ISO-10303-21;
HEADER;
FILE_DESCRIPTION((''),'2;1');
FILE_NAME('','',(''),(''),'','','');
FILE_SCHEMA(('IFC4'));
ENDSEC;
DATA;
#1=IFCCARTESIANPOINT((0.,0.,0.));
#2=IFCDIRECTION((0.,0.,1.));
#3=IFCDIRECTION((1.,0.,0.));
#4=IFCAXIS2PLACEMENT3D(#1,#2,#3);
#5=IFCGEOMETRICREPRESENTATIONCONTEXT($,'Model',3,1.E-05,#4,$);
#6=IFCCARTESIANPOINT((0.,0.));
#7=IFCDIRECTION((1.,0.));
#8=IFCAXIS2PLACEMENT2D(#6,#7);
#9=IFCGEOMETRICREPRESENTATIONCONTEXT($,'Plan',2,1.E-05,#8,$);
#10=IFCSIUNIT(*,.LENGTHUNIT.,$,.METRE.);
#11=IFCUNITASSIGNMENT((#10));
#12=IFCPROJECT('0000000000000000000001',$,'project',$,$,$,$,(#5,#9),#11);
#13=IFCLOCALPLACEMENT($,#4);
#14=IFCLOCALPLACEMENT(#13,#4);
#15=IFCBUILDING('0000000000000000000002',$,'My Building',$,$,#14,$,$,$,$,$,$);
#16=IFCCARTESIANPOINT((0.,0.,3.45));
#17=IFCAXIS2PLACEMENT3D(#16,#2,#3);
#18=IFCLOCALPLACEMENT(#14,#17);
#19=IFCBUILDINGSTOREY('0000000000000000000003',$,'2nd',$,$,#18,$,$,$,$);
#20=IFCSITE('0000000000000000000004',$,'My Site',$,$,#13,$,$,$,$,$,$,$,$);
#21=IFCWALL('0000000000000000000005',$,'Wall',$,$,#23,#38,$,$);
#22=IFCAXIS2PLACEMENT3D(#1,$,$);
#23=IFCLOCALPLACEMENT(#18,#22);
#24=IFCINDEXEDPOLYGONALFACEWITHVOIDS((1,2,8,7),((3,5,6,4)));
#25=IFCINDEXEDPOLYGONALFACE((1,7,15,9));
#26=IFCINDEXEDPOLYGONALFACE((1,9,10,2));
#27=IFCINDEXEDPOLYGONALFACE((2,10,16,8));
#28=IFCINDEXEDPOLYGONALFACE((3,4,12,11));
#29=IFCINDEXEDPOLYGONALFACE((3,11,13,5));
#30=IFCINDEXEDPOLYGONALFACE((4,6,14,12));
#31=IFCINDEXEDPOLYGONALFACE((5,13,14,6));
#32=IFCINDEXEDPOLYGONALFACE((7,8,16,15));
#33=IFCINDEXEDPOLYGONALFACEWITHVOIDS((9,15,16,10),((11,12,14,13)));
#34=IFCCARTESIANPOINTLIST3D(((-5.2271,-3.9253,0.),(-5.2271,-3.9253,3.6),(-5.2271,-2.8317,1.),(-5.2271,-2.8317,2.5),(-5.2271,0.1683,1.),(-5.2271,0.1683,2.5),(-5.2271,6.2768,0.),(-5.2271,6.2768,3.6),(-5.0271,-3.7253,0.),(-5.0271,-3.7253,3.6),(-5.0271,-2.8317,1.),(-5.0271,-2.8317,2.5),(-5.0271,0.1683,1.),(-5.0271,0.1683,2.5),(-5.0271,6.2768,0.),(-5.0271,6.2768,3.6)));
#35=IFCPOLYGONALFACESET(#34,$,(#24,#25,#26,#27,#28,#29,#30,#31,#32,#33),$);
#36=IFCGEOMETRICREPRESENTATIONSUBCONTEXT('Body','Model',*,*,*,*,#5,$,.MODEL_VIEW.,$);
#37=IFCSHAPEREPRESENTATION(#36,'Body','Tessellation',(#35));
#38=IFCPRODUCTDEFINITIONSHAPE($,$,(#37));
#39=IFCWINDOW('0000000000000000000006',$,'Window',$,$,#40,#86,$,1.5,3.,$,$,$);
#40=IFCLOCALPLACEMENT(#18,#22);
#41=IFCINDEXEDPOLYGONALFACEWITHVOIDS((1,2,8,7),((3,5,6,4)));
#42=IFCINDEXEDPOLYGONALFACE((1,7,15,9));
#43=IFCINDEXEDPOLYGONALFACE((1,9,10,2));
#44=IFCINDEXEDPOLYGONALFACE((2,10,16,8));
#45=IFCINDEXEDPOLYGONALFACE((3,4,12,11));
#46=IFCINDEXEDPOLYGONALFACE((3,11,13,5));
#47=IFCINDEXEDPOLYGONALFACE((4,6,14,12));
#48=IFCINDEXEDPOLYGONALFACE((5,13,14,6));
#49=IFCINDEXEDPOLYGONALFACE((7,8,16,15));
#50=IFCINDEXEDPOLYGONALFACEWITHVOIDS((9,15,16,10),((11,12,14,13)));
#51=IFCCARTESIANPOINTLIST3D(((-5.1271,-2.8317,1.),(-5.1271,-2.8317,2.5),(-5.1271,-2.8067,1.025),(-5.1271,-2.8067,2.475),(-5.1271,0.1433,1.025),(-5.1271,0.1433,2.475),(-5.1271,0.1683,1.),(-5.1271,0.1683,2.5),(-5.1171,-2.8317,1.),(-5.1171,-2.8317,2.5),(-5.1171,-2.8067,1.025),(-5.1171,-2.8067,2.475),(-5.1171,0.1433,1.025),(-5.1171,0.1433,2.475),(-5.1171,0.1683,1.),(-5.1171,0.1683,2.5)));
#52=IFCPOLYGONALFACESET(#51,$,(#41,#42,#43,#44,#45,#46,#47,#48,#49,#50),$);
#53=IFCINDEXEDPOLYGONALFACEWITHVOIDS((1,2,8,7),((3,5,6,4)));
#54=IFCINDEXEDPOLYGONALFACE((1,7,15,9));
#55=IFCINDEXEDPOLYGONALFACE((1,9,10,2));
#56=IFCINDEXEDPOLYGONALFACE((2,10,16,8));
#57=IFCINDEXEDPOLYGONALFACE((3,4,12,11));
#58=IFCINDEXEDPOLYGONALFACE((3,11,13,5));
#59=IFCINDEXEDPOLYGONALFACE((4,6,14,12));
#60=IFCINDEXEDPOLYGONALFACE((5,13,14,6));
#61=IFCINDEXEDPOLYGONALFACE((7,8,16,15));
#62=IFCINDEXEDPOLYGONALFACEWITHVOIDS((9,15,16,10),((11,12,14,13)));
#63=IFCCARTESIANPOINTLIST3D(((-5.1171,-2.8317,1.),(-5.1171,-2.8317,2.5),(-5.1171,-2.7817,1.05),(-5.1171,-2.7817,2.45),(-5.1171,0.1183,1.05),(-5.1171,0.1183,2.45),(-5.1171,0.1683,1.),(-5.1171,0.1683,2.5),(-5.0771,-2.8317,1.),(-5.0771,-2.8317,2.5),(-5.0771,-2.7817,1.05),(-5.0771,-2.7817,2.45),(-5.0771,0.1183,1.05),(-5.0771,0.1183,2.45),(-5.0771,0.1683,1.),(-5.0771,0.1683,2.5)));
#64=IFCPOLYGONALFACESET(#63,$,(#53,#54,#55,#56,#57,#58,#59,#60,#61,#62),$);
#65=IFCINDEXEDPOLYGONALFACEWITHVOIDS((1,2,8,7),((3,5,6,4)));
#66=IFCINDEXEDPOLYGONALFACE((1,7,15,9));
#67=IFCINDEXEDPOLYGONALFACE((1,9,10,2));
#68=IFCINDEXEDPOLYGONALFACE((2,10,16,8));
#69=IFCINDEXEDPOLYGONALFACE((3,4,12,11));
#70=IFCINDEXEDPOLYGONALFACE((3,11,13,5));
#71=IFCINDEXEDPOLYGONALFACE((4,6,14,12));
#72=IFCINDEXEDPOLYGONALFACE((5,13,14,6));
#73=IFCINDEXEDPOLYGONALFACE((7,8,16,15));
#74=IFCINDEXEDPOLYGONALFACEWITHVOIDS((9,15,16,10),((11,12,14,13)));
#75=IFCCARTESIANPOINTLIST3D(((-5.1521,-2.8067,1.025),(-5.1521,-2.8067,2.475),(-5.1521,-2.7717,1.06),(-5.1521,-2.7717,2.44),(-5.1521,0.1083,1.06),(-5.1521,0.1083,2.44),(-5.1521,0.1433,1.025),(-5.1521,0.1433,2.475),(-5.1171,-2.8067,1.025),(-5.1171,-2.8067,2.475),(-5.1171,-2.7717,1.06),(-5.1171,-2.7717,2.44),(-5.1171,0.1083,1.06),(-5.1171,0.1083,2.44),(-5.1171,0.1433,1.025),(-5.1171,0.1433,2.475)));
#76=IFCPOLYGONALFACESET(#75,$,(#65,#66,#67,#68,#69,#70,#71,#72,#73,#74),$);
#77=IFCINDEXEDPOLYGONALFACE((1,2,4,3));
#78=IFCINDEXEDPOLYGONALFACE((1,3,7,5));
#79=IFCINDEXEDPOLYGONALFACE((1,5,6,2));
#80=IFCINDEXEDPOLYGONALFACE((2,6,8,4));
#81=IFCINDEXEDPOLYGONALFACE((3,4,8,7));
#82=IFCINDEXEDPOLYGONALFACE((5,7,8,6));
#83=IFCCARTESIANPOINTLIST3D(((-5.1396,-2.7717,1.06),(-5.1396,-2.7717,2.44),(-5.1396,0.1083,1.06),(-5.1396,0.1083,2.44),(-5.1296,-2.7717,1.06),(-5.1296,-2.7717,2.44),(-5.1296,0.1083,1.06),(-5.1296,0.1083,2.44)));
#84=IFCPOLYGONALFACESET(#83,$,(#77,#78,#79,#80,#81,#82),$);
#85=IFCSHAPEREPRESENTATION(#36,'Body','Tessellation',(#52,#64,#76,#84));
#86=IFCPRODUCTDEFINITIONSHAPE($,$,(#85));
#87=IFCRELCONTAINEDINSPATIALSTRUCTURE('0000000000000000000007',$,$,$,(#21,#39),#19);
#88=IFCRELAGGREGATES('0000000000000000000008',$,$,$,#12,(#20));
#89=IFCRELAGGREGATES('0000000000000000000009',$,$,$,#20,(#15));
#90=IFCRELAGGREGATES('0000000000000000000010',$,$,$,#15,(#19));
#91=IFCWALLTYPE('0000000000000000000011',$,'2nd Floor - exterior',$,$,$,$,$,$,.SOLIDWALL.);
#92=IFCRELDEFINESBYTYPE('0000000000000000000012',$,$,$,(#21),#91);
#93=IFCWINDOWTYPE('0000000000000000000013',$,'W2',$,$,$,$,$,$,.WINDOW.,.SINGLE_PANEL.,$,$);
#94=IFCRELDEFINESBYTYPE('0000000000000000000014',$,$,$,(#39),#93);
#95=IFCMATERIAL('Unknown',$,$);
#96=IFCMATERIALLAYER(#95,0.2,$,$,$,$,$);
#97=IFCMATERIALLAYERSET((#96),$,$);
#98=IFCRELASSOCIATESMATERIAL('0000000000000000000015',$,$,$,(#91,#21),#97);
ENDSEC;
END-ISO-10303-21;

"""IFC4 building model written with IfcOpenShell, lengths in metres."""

from ifc_helpers import new_model, entity, si_unit, frame, origin_with_axes, origin_2d_with_axis, place, context, subcontext, project, spatial, line, indexed_curve, outline, extrude, shape, source, transform, mapped, material, layer, layer_set, layer_usage, type_object, type_shapes, element, fill, save


model = new_model("IFC4")

# Units and contexts
model_context = context("Model", 3, precision=1e-05, world=origin_with_axes())
plan_context = context("Plan", 2, precision=1e-05, world=origin_2d_with_axis())
body_context_1 = subcontext(model_context, "Body", "Model", "MODEL_VIEW")
body_context_2 = subcontext(plan_context, "Body", "Plan", "PLAN_VIEW")
ifc_project = project(units=[si_unit("LENGTHUNIT", "METRE")], contexts=[model_context, plan_context])

# Site, building, storey
site_placement = place(None, origin_with_axes())
site = spatial("IfcSite", under=ifc_project, at=site_placement, Name="My Site")
building_placement = place(site_placement, origin_with_axes())
building = spatial("IfcBuilding", under=site, at=building_placement, Name="My Building")
storey_placement = place(building_placement, frame((0.0, 0.0, 3.45), z_axis=(0.0, 0.0, 1.0), x_axis=(1.0, 0.0, 0.0)))
storey = spatial("IfcBuildingStorey", under=building, at=storey_placement, Name="2nd")

# Shared definitions
ifc_material = material(Name="Unknown")

# Wall, opening, window
ifc_layer_1 = layer(ifc_material, 0.2)
ifc_layer_set_1 = layer_set([ifc_layer_1])
ifc_layer_usage_1 = layer_usage(ifc_layer_set_1, "AXIS2", "POSITIVE", 0.0)
wall_type_1 = type_object("IfcWallType", Name="2nd Floor - exterior", PredefinedType="SOLIDWALL", material=ifc_layer_set_1)
wall_1_placement = place(storey_placement, frame((-5.2271, 6.2768, 0.0), z_axis=(0.0, 0.0, 1.0), x_axis=(0.0, -1.0, 0.0)))
wall_1 = element("IfcWall", 1, at=wall_1_placement, inside=storey, type_object=wall_type_1, material=ifc_layer_usage_1, Name="Wall", context=body_context_1, shape_type="SweptSolid", body=[
    extrude(outline(indexed_curve([(0.0, 0.0), (0.0, 0.2), (10.0021, 0.2), (10.2021, 0.0)], segments=[line(1, 2, 3, 4, 1)])), origin_with_axes(), (0.0, 0.0, 1.0), 3.6),
])
shared_shape_1 = source(origin_with_axes(), body_context_1, "Body", "SweptSolid", [
    extrude(outline(indexed_curve([(0.0, 0.0), (3.0, 0.0), (3.0, 1.5), (0.0, 1.5)], segments=[line(1, 2, 3, 4, 1)])), frame((0.0, -0.6, 0.0), z_axis=(0.0, -1.0, 0.0), x_axis=(1.0, 0.0, 0.0)), (0.0, 0.0, -1.0), 1.2),
])
opening_1_placement = place(wall_1_placement, frame((9.1085, 0.2, 1.0), z_axis=(0.0, 0.0, 1.0), x_axis=(-1.0, 0.0, 0.0)))
opening_1 = element("IfcOpeningElement", 2, at=opening_1_placement, cuts=wall_1, PredefinedType="OPENING", context=body_context_1, shape_type="MappedRepresentation", body=[
    mapped(shared_shape_1, transform((0.0, 0.0, 0.0), x_axis=(1.0, 0.0, 0.0), y_axis=(0.0, 1.0, 0.0), z_axis=(0.0, 0.0, 1.0), scale=1.0)),
])
window_type = type_object("IfcWindowType", Name="W2", PartitioningType="SINGLE_PANEL", PredefinedType="WINDOW")
shared_shape_2 = source(origin_with_axes(), body_context_1, "Body", "SweptSolid", [
    extrude(outline(indexed_curve([(0.0, 0.0), (3.0, 0.0), (3.0, 1.5), (0.0, 1.5)], segments=[line(1, 2, 3, 4, 1)]), holes=[indexed_curve([(0.025, 0.025), (2.975, 0.025), (2.975, 1.475), (0.025, 1.475)], segments=[line(1, 2, 3, 4, 1)])]), frame((0.0, 0.09, 0.0), z_axis=(0.0, -1.0, 0.0), x_axis=(1.0, 0.0, 0.0)), (0.0, 0.0, -1.0), 0.01),
    extrude(outline(indexed_curve([(0.0, 0.0), (3.0, 0.0), (3.0, 1.5), (0.0, 1.5)], segments=[line(1, 2, 3, 4, 1)]), holes=[indexed_curve([(0.05, 0.05), (2.95, 0.05), (2.95, 1.45), (0.05, 1.45)], segments=[line(1, 2, 3, 4, 1)])]), frame((0.0, 0.05, 0.0), z_axis=(0.0, -1.0, 0.0), x_axis=(1.0, 0.0, 0.0)), (0.0, 0.0, -1.0), 0.04),
    extrude(outline(indexed_curve([(0.0, 0.0), (2.95, 0.0), (2.95, 1.45), (0.0, 1.45)], segments=[line(1, 2, 3, 4, 1)]), holes=[indexed_curve([(0.035, 0.035), (2.915, 0.035), (2.915, 1.415), (0.035, 1.415)], segments=[line(1, 2, 3, 4, 1)])]), frame((0.025, 0.09, 0.025), z_axis=(0.0, -1.0, 0.0), x_axis=(1.0, 0.0, 0.0)), (0.0, 0.0, -1.0), 0.035),
    extrude(outline(indexed_curve([(0.035, 0.035), (2.915, 0.035), (2.915, 1.415), (0.035, 1.415)], segments=[line(1, 2, 3, 4, 1)])), frame((0.025, 0.1025, 0.025), z_axis=(0.0, -1.0, 0.0), x_axis=(1.0, 0.0, 0.0)), (0.0, 0.0, -1.0), 0.01),
])
shared_shape_3 = source(origin_with_axes(), body_context_2, "Body", "Curve2D", [
    entity("IfcIndexedPolyCurve", entity("IfcCartesianPointList2D", [[0.05, 0.05], [2.95, 0.05]])),
    entity("IfcIndexedPolyCurve", entity("IfcCartesianPointList2D", [[0.0, 0.1], [0.025, 0.1], [0.025, 0.09], [0.05, 0.09], [0.05, 0.05], [0.0, 0.05]]), [entity("IfcLineIndex", [1, 2, 3, 4, 5, 6, 1])]),
    entity("IfcIndexedPolyCurve", entity("IfcCartesianPointList2D", [[3.0, 0.1], [2.975, 0.1], [2.975, 0.09], [2.95, 0.09], [2.95, 0.05], [3.0, 0.05]]), [entity("IfcLineIndex", [1, 2, 3, 4, 5, 6, 1])]),
    entity("IfcIndexedPolyCurve", entity("IfcCartesianPointList2D", [[0.025, 0.09], [0.06, 0.09], [0.06, 0.125], [0.025, 0.125]]), [entity("IfcLineIndex", [1, 2, 3, 4, 1])]),
    entity("IfcIndexedPolyCurve", entity("IfcCartesianPointList2D", [[2.975, 0.09], [2.94, 0.09], [2.94, 0.125], [2.975, 0.125]]), [entity("IfcLineIndex", [1, 2, 3, 4, 1])]),
    entity("IfcIndexedPolyCurve", entity("IfcCartesianPointList2D", [[0.06, 0.09], [2.94, 0.09]])),
    entity("IfcIndexedPolyCurve", entity("IfcCartesianPointList2D", [[0.06, 0.125], [2.94, 0.125]])),
    entity("IfcIndexedPolyCurve", entity("IfcCartesianPointList2D", [[0.06, 0.1075], [2.94, 0.1075]])),
])
type_shapes(window_type, [shared_shape_2, shared_shape_3])
window_1_placement = place(opening_1_placement, frame((0.0, 0.0, 0.0), z_axis=(0.0, 0.0, 1.0), x_axis=(1.0, 0.0, 0.0)))
window_1 = element("IfcWindow", 3, at=window_1_placement, inside=storey, type_object=window_type, Name="Window", OverallHeight=1.5, OverallWidth=3.0, shapes=[
    shape(body_context_1, "Body", "MappedRepresentation", [mapped(shared_shape_2, transform((0.0, 0.0, 0.0), x_axis=(1.0, 0.0, 0.0), y_axis=(0.0, 1.0, 0.0), z_axis=(0.0, 0.0, 1.0), scale=1.0))]),
    shape(body_context_2, "Body", "MappedRepresentation", [mapped(shared_shape_3, transform((0.0, 0.0, 0.0), x_axis=(1.0, 0.0, 0.0), y_axis=(0.0, 1.0, 0.0), z_axis=(0.0, 0.0, 1.0), scale=1.0))]),
])
fill(opening_1, window_1)

save(model, "model.ifc")
